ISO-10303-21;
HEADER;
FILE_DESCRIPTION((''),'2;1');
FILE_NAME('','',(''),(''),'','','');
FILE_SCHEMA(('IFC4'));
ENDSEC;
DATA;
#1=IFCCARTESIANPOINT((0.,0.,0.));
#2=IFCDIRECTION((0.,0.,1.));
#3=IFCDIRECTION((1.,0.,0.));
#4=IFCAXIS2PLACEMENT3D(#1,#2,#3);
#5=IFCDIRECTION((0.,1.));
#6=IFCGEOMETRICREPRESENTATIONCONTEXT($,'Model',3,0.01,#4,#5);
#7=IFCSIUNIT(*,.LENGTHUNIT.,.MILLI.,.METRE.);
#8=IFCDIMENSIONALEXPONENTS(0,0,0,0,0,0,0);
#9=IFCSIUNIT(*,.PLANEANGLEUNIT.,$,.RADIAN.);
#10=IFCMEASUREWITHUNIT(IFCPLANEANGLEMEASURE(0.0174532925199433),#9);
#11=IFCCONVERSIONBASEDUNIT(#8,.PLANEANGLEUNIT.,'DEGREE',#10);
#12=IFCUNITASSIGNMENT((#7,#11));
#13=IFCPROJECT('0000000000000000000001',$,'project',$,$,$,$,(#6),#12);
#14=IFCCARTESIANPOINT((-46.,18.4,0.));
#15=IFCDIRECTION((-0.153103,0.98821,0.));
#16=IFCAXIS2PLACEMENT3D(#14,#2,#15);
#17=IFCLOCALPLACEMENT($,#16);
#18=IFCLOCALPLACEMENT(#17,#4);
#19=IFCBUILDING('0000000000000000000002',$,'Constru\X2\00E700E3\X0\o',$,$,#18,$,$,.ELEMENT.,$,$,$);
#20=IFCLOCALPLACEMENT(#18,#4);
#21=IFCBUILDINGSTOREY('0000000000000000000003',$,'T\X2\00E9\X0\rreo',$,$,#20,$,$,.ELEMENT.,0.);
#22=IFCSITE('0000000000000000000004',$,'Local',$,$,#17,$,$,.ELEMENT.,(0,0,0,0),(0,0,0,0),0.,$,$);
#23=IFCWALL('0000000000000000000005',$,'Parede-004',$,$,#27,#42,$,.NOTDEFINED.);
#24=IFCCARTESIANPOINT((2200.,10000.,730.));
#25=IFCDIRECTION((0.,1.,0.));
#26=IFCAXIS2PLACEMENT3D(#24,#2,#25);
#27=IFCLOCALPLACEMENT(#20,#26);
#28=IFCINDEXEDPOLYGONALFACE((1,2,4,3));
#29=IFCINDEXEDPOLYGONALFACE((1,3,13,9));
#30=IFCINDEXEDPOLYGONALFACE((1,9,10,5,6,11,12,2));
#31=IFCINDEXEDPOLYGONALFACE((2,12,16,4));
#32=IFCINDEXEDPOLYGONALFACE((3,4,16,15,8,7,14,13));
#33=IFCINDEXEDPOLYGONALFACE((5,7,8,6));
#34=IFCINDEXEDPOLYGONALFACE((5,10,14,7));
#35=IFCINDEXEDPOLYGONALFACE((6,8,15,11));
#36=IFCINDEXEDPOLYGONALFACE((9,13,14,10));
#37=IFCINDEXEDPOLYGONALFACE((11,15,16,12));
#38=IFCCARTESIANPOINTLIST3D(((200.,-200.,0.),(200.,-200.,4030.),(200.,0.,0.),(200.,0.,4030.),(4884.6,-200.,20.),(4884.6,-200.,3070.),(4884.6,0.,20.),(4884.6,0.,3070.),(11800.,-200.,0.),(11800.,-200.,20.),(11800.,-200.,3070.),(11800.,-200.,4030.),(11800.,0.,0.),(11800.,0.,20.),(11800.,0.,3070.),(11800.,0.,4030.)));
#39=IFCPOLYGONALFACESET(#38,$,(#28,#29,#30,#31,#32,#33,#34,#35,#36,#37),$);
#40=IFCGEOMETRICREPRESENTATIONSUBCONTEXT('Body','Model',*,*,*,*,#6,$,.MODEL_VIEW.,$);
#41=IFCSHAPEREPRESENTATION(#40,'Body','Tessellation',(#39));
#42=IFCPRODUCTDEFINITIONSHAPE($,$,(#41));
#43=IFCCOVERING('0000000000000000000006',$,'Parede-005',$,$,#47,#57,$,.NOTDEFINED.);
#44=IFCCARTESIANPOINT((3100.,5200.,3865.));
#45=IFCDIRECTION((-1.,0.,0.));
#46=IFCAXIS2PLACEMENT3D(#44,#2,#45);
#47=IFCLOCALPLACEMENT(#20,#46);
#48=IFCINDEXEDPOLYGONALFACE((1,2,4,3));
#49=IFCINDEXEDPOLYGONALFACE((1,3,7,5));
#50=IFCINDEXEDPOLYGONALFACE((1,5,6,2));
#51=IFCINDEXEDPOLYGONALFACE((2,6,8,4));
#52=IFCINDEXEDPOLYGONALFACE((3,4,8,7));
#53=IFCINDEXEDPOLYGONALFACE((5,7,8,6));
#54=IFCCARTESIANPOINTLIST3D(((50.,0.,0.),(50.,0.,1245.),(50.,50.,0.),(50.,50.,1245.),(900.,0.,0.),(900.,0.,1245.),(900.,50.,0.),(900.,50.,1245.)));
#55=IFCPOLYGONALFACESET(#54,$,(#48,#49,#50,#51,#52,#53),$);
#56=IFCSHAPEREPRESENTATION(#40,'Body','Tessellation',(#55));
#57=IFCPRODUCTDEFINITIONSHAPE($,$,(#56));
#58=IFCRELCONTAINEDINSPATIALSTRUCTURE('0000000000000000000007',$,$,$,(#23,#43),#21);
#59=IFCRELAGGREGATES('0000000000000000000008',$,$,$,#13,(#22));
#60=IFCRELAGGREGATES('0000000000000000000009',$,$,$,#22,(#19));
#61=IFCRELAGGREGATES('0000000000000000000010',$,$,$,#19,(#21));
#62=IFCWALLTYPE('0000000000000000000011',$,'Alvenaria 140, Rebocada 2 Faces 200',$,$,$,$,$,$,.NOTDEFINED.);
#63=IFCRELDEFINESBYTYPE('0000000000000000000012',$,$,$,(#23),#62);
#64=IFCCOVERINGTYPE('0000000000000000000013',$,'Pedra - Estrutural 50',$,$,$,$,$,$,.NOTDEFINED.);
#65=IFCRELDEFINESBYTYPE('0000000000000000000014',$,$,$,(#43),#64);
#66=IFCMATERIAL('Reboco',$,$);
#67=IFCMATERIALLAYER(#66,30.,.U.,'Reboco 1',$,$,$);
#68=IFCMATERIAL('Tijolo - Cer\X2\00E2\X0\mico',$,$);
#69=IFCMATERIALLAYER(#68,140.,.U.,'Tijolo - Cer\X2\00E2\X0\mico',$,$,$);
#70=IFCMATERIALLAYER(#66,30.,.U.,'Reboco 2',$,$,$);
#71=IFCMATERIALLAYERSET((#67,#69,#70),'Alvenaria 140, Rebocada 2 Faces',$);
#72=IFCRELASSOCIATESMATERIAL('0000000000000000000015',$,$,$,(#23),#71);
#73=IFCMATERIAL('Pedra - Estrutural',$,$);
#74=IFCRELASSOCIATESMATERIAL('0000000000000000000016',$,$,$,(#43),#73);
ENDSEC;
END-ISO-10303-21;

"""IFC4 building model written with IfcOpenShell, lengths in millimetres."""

from ifc_helpers import new_model, entity, si_unit, converted_unit, direction, frame, origin_with_axes, origin_2d_with_axis, place, context, subcontext, project, spatial, line, indexed_curve, rectangle, outline, extrude, material, layer, layer_set, layer_usage, type_object, element, save


model = new_model("IFC4")

# Units and contexts
model_context = context("Model", 3, precision=0.01, world=origin_with_axes(), true_north=direction((0.0, 1.0)))
body_context = subcontext(model_context, "Body", "Model", "MODEL_VIEW")
ifc_project = project(units=[si_unit("LENGTHUNIT", "METRE", prefix="MILLI"), converted_unit("PLANEANGLEUNIT", "DEGREE", entity("IfcPlaneAngleMeasure", 0.0174532925199433), si_unit("PLANEANGLEUNIT", "RADIAN"), dimensions=[0, 0, 0, 0, 0, 0, 0])], contexts=[model_context])

# Site, building, storey
site_placement = place(None, frame((-46.0, 18.4, 0.0), z_axis=(0.0, 0.0, 1.0), x_axis=(-0.153103, 0.98821, 0.0)))
site = spatial("IfcSite", under=ifc_project, at=site_placement, Name="Local", CompositionType="ELEMENT", RefLatitude=(0, 0, 0, 0), RefLongitude=(0, 0, 0, 0), RefElevation=0.0)
building_placement = place(site_placement, origin_with_axes())
building = spatial("IfcBuilding", under=site, at=building_placement, Name="Construção", CompositionType="ELEMENT")
storey_placement = place(building_placement, origin_with_axes())
storey = spatial("IfcBuildingStorey", under=building, at=storey_placement, Name="Térreo", CompositionType="ELEMENT", Elevation=0.0)

# Shared definitions
ifc_material_1 = material(Name="Reboco")
ifc_layer_1 = layer(ifc_material_1, 30.0, ventilated="UNKNOWN", Name="Reboco 1")
ifc_material_2 = material(Name="Tijolo - Cerâmico")
ifc_layer_2 = layer(ifc_material_2, 140.0, ventilated="UNKNOWN", Name="Tijolo - Cerâmico")
ifc_layer_3 = layer(ifc_material_1, 30.0, ventilated="UNKNOWN", Name="Reboco 2")
ifc_layer_set_1 = layer_set([ifc_layer_1, ifc_layer_2, ifc_layer_3], Name="Alvenaria 140, Rebocada 2 Faces")
wall_type_1 = type_object("IfcWallType", Name="Alvenaria 140, Rebocada 2 Faces 200", PredefinedType="NOTDEFINED")

# Wall, opening
ifc_layer_usage_1 = layer_usage(ifc_layer_set_1, "AXIS2", "NEGATIVE", 0.0)
wall_1_placement = place(storey_placement, frame((2200.0, 10000.0, 730.0), z_axis=(0.0, 0.0, 1.0), x_axis=(0.0, 1.0, 0.0)))
wall_1 = element("IfcWall", 1, at=wall_1_placement, inside=storey, type_object=wall_type_1, material=ifc_layer_usage_1, Name="Parede-004", PredefinedType="NOTDEFINED", context=body_context, shape_type="SweptSolid", body=[
    extrude(outline(indexed_curve([(200.0, -200.0), (11800.0, -200.0), (11800.0, 0.0), (200.0, 0.0)], segments=[line(1, 2, 3, 4, 1)])), origin_with_axes(), (0.0, 0.0, 1.0), 4030.0),
])
opening_1_placement = place(wall_1_placement, frame((8342.3, 0.0, 20.0), z_axis=(0.0, 0.0, 1.0), x_axis=(1.0, 0.0, 0.0)))
element("IfcOpeningElement", 2, at=opening_1_placement, cuts=wall_1, context=body_context, shape_type="SweptSolid", body=[
    extrude(rectangle(XDim=6915.4, YDim=3050.0, at=origin_2d_with_axis()), frame((0.0, -200.0, 1525.0), z_axis=(0.0, 1.0, 0.0), x_axis=(-1.0, 0.0, 0.0)), (0.0, 0.0, 1.0), 600.0),
])

# Shared definitions
ifc_material_3 = material(Name="Pedra - Estrutural")
covering_type_1 = type_object("IfcCoveringType", Name="Pedra - Estrutural 50", PredefinedType="NOTDEFINED")

# Covering
covering_1_placement = place(storey_placement, frame((3100.0, 5200.0, 3865.0), z_axis=(0.0, 0.0, 1.0), x_axis=(-1.0, 0.0, 0.0)))
element("IfcCovering", 3, at=covering_1_placement, inside=storey, type_object=covering_type_1, material=ifc_material_3, Name="Parede-005", PredefinedType="NOTDEFINED", context=body_context, shape_type="SweptSolid", body=[
    extrude(outline(indexed_curve([(50.0, 0.0), (900.0, 0.0), (900.0, 50.0), (50.0, 50.0)], segments=[line(1, 2, 3, 4, 1)])), origin_with_axes(), (0.0, 0.0, 1.0), 1245.0),
])

save(model, "model.ifc")
